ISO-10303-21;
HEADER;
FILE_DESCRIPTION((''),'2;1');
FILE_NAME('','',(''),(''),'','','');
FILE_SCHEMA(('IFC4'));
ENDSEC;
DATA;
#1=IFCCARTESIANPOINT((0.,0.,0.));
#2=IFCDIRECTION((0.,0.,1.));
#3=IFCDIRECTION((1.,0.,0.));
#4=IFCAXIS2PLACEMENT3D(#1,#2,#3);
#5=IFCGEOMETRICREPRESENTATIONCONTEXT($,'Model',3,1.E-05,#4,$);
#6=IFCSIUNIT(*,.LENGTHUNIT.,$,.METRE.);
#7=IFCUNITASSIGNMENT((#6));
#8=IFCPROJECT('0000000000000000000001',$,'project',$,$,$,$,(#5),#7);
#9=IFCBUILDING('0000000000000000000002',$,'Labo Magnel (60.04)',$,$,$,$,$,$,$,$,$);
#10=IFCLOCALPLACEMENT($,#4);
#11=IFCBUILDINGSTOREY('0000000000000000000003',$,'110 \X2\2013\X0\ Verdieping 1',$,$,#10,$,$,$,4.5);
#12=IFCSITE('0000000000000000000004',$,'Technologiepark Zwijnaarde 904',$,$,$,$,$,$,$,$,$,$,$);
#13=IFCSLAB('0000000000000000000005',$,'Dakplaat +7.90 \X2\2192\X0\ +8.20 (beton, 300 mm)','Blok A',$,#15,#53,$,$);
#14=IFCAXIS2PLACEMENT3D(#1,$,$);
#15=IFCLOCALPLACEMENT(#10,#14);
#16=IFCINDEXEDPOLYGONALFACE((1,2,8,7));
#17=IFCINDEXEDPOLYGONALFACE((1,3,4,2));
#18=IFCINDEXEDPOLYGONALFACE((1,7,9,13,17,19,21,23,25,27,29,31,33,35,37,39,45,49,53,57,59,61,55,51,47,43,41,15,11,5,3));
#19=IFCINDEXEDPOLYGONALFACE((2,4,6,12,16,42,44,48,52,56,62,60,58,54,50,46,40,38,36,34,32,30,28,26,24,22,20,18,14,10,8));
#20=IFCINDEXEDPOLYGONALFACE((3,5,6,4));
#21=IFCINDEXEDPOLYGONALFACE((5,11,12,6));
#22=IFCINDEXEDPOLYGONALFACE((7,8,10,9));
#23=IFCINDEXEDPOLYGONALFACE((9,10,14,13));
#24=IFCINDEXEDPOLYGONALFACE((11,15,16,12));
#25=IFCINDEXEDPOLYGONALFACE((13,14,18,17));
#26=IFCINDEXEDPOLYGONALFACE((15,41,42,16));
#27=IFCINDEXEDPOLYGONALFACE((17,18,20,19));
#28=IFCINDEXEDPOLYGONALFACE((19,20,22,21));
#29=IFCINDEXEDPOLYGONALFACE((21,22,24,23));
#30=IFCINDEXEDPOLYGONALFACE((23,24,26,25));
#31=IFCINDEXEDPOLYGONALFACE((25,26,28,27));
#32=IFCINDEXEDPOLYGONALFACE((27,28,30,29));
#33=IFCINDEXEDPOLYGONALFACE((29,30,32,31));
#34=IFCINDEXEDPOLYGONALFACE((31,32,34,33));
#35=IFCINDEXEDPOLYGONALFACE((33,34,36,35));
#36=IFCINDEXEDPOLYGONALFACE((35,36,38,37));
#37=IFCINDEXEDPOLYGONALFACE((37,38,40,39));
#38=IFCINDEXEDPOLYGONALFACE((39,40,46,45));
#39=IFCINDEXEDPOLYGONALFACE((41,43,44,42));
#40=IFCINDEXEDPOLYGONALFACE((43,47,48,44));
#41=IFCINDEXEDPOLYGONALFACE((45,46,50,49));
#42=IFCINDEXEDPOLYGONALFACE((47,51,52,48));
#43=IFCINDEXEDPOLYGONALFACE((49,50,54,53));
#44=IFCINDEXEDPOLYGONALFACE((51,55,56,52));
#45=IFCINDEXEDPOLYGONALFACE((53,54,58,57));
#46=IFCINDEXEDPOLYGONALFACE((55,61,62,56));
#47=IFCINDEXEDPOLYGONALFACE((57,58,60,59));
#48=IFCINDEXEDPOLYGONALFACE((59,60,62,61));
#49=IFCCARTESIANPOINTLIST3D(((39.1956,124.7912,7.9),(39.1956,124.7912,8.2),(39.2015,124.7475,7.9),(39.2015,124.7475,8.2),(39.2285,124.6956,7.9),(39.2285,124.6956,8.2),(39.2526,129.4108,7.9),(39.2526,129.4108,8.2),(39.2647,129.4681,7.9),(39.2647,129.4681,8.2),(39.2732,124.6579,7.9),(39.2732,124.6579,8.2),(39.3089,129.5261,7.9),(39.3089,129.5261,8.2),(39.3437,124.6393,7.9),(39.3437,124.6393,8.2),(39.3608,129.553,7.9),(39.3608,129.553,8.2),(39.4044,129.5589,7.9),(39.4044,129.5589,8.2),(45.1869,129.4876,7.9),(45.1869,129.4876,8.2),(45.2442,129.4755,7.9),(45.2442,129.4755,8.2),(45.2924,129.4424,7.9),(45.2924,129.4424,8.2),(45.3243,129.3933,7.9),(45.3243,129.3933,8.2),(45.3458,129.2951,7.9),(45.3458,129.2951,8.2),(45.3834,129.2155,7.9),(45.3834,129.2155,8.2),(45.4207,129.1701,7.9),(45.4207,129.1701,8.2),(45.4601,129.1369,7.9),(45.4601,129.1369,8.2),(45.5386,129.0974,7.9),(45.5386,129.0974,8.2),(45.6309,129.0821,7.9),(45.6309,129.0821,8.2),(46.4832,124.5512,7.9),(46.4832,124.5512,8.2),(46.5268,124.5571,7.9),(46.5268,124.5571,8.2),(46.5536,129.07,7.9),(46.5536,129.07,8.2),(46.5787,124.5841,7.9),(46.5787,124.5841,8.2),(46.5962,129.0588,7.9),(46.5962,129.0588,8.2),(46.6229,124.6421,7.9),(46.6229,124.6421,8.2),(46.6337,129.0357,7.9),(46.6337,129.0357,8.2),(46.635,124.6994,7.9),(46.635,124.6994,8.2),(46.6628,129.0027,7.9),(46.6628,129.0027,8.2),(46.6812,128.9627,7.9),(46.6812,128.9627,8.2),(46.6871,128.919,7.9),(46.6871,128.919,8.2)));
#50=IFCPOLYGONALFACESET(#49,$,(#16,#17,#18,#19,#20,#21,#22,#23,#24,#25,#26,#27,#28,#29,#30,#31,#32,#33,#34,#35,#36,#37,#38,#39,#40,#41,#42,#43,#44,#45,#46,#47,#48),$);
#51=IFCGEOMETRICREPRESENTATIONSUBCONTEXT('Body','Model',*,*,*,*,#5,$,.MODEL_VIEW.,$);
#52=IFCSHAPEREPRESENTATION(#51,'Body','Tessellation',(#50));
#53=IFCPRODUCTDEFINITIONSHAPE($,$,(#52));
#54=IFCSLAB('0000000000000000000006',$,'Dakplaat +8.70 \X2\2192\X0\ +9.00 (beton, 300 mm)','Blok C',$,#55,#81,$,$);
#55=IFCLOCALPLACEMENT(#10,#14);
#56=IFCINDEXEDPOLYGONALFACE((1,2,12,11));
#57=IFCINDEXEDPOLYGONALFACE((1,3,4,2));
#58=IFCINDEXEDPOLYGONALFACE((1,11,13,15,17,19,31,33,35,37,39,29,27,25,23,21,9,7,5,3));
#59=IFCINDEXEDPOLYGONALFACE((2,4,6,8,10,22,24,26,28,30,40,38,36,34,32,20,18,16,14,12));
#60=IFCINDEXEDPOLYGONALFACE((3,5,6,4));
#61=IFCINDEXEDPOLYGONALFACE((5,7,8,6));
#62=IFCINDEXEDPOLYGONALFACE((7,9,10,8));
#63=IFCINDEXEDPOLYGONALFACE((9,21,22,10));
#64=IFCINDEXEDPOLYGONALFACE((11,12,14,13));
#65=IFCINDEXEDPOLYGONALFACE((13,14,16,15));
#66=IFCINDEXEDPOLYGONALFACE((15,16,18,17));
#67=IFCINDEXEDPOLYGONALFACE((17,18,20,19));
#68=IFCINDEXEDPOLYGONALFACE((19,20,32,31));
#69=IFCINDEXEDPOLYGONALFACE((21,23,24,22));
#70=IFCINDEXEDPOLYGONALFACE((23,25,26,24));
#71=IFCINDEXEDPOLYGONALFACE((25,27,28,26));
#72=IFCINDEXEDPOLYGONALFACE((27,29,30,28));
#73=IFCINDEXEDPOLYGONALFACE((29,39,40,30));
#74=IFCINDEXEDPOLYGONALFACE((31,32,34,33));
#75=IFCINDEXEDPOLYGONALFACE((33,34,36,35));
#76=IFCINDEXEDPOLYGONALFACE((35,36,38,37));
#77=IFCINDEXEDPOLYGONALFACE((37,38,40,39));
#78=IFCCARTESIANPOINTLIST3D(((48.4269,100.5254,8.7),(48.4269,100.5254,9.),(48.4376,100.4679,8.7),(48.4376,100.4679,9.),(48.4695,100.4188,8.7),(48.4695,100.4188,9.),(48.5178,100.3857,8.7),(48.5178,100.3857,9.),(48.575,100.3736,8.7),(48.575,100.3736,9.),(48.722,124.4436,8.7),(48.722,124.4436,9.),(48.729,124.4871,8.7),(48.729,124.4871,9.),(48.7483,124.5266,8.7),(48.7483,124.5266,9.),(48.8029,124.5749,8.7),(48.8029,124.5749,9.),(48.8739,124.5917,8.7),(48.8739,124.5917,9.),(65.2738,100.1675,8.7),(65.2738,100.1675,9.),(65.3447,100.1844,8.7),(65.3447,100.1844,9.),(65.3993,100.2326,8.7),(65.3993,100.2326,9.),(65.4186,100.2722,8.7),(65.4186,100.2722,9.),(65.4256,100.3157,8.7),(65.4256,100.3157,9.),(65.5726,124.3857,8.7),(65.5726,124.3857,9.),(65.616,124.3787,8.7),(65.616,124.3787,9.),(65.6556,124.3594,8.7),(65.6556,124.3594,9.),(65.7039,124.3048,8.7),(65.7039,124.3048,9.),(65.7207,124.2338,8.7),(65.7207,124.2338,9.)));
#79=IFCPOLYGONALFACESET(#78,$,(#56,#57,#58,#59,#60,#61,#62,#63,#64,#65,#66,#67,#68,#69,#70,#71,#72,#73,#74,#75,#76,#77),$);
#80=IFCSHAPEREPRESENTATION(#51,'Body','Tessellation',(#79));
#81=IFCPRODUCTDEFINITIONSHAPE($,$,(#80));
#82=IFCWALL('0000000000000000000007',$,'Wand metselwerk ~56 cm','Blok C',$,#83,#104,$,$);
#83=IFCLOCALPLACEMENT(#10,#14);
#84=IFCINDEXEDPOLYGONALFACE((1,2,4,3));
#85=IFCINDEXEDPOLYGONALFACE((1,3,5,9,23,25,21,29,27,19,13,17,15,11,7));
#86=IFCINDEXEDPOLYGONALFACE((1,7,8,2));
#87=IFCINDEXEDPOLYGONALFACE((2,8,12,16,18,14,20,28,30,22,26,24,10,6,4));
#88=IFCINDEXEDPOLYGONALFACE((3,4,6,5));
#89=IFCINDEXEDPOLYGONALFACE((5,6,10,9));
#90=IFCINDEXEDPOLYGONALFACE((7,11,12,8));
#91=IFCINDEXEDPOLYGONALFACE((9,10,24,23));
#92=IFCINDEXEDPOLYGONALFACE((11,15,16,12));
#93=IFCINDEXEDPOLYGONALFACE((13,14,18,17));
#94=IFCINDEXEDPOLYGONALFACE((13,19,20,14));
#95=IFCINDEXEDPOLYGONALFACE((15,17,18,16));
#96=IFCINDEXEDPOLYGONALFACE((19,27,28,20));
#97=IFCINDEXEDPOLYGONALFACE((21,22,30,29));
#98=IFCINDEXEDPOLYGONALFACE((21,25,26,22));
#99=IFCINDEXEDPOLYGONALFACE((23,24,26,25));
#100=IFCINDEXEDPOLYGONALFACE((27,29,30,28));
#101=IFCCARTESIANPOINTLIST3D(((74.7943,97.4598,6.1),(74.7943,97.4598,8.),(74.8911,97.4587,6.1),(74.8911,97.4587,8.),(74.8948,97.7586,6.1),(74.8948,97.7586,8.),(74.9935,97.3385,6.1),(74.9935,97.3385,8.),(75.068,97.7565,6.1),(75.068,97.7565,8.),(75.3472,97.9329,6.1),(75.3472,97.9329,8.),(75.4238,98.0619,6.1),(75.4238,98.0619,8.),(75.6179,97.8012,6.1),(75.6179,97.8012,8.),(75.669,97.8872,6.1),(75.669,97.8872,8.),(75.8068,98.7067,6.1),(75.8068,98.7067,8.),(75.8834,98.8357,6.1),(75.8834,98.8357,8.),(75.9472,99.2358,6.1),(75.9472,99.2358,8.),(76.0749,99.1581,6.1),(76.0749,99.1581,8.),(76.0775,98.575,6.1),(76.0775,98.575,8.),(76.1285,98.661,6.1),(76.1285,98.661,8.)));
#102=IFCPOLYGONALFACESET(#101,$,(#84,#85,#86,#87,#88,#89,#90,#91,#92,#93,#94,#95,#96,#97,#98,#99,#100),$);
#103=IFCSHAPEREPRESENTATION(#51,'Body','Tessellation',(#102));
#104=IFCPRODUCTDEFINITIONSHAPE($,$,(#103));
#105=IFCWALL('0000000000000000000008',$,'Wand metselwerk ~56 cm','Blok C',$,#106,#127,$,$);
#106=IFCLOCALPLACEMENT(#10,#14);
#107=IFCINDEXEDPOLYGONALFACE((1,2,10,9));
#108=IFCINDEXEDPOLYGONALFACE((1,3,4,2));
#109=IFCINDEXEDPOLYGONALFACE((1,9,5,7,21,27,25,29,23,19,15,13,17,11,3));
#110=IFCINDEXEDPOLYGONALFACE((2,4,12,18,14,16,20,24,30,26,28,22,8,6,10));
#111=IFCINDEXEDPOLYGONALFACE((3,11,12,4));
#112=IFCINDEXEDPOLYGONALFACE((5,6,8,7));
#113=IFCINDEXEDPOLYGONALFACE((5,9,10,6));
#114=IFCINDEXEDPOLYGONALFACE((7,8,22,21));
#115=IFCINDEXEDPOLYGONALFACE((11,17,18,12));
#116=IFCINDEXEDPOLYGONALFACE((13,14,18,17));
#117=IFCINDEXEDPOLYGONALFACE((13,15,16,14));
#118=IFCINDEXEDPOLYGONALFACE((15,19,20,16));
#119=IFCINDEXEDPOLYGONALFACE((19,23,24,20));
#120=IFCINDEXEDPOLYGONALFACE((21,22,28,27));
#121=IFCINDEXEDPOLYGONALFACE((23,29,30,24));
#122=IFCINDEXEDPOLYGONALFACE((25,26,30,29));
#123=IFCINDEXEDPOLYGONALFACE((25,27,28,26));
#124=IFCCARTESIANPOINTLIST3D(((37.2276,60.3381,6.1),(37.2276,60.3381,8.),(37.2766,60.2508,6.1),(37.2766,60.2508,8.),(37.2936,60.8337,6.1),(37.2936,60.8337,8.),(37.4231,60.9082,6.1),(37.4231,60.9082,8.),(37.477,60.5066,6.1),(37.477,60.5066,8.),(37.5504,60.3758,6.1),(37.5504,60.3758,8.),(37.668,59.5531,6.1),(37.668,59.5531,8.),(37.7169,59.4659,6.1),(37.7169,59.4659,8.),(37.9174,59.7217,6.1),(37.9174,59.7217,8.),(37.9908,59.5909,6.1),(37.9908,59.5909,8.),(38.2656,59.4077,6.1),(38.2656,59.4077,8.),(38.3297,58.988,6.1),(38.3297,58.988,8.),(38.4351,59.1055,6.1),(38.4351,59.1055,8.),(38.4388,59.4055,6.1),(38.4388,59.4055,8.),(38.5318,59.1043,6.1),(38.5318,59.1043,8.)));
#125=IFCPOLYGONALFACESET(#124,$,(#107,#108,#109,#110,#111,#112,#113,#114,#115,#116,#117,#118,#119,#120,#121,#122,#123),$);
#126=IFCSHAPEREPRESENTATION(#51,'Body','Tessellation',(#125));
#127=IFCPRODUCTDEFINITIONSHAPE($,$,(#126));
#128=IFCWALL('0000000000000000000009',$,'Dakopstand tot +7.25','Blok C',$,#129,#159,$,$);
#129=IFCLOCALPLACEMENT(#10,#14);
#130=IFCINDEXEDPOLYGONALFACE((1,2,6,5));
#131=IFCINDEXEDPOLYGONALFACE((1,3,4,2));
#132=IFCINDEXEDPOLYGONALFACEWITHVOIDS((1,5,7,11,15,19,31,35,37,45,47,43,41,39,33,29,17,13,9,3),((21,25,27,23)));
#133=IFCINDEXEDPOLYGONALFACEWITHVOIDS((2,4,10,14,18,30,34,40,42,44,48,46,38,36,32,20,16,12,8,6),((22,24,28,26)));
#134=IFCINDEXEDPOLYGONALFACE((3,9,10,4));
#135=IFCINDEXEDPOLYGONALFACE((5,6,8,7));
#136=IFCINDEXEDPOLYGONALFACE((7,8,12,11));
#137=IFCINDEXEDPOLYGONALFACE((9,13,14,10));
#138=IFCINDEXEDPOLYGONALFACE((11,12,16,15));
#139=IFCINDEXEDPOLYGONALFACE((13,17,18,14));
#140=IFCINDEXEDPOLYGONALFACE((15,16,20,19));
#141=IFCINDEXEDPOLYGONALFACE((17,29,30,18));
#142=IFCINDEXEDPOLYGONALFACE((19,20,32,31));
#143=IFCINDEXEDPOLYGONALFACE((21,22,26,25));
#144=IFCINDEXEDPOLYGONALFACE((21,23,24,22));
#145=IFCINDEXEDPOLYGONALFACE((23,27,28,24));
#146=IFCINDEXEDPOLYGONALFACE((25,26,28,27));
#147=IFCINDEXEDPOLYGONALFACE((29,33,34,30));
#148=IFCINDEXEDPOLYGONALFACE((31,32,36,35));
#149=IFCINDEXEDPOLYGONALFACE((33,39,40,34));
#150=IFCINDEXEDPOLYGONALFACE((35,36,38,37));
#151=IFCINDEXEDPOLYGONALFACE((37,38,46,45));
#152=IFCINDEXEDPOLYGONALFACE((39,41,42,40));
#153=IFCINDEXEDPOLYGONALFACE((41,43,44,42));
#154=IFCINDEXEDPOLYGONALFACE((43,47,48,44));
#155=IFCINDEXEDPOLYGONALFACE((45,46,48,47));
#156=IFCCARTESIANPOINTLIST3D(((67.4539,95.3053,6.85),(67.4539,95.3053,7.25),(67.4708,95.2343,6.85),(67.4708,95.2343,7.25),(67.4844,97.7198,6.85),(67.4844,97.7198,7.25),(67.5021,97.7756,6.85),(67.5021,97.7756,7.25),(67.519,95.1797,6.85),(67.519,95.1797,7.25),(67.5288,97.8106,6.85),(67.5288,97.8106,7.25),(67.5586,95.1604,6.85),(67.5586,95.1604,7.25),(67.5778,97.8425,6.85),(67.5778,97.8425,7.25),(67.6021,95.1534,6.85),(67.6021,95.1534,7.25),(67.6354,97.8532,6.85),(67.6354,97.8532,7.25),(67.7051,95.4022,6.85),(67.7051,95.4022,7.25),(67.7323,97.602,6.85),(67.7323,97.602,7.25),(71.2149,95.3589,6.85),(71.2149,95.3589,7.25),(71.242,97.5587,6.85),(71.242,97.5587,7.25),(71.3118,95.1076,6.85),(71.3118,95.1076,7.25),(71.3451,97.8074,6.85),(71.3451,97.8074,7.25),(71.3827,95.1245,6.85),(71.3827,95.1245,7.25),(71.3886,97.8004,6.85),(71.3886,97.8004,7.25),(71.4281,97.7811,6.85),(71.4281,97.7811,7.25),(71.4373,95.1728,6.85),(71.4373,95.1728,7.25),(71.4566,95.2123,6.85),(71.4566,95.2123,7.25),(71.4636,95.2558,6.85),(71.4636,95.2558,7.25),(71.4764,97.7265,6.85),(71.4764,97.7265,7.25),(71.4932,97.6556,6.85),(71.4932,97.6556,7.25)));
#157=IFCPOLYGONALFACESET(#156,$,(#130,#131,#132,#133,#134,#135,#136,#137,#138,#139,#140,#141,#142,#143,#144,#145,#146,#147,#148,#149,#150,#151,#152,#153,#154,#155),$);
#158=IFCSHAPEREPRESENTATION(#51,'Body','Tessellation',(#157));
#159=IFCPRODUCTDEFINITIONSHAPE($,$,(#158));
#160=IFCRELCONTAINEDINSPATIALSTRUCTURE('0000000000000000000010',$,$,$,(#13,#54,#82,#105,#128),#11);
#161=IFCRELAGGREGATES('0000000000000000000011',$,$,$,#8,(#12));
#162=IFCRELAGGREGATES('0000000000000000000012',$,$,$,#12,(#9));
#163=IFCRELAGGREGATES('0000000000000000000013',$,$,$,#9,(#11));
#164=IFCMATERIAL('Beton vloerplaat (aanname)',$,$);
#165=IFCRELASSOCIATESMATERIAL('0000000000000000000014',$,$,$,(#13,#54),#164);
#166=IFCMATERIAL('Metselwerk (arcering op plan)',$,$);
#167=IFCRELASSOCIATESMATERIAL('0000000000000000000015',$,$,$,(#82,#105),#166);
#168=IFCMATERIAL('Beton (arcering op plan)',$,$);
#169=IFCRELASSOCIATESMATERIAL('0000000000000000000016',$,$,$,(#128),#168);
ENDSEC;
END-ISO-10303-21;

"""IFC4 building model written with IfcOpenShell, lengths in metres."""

from ifc_helpers import new_model, si_unit, frame, origin, origin_with_axes, place, context, subcontext, project, spatial, polyline, outline, extrude, material, element, save


model = new_model("IFC4")

# Units and contexts
model_context = context("Model", 3, precision=1e-05, world=origin_with_axes())
body_context = subcontext(model_context, "Body", "Model", "MODEL_VIEW")
ifc_project = project(units=[si_unit("LENGTHUNIT", "METRE")], contexts=[model_context])

# Site, building, storey
site = spatial("IfcSite", under=ifc_project, Name="Technologiepark Zwijnaarde 904")
building = spatial("IfcBuilding", under=site, Name="Labo Magnel (60.04)")
storey_placement = place(None, origin_with_axes())
storey = spatial("IfcBuildingStorey", under=building, at=storey_placement, Name="110 – Verdieping 1", Elevation=4.5)

# Shared definitions
ifc_material_1 = material(Name="Metselwerk (arcering op plan)")
ifc_material_2 = material(Name="Beton (arcering op plan)")

# Slabs
ifc_material_3 = material(Name="Beton vloerplaat (aanname)")
slab_1_placement = place(storey_placement, frame((0.0, 0.0, 7.9), z_axis=(0.0, 0.0, 1.0), x_axis=(1.0, 0.0, 0.0)))
element("IfcSlab", 1, at=slab_1_placement, inside=storey, material=ifc_material_3, Name="Dakplaat +7.90 → +8.20 (beton, 300 mm)", Description="Blok A", context=body_context, shape_type="SweptSolid", body=[
    extrude(outline(polyline([(45.1869, 129.4876), (45.2442, 129.4755), (45.2924, 129.4424), (45.3243, 129.3933), (45.3458, 129.2951), (45.3834, 129.2155), (45.4207, 129.1701), (45.4601, 129.1369), (45.5386, 129.0974), (45.6309, 129.0821), (46.5536, 129.07), (46.5962, 129.0588), (46.6337, 129.0357), (46.6628, 129.0027), (46.6812, 128.9627), (46.6871, 128.919), (46.635, 124.6994), (46.6229, 124.6421), (46.5787, 124.5841), (46.5268, 124.5571), (46.4832, 124.5512), (39.3437, 124.6393), (39.2732, 124.6579), (39.2285, 124.6956), (39.2015, 124.7475), (39.1956, 124.7912), (39.2526, 129.4108), (39.2647, 129.4681), (39.3089, 129.5261), (39.3608, 129.553), (39.4044, 129.5589), (45.1869, 129.4876)])), origin(), (0.0, 0.0, 1.0), 0.3),
])
slab_2_placement = place(storey_placement, frame((0.0, 0.0, 8.7), z_axis=(0.0, 0.0, 1.0), x_axis=(1.0, 0.0, 0.0)))
element("IfcSlab", 2, at=slab_2_placement, inside=storey, material=ifc_material_3, Name="Dakplaat +8.70 → +9.00 (beton, 300 mm)", Description="Blok C", context=body_context, shape_type="SweptSolid", body=[
    extrude(outline(polyline([(48.575, 100.3736), (48.5178, 100.3857), (48.4695, 100.4188), (48.4376, 100.4679), (48.4269, 100.5254), (48.722, 124.4436), (48.729, 124.4871), (48.7483, 124.5266), (48.8029, 124.5749), (48.8739, 124.5917), (65.5726, 124.3857), (65.616, 124.3787), (65.6556, 124.3594), (65.7039, 124.3048), (65.7207, 124.2338), (65.4256, 100.3157), (65.4186, 100.2722), (65.3993, 100.2326), (65.3447, 100.1844), (65.2738, 100.1675), (48.575, 100.3736)])), origin(), (0.0, 0.0, 1.0), 0.3),
])

# Walls
wall_1_placement = place(storey_placement, frame((0.0, 0.0, 6.1), z_axis=(0.0, 0.0, 1.0), x_axis=(1.0, 0.0, 0.0)))
element("IfcWall", 3, at=wall_1_placement, inside=storey, material=ifc_material_1, Name="Wand metselwerk ~56 cm", Description="Blok C", context=body_context, shape_type="SweptSolid", body=[
    extrude(outline(polyline([(75.3472, 97.9329), (75.6179, 97.8012), (75.669, 97.8872), (75.4238, 98.0619), (75.8068, 98.7067), (76.0775, 98.575), (76.1285, 98.661), (75.8834, 98.8357), (76.0749, 99.1581), (75.9472, 99.2358), (75.068, 97.7565), (74.8948, 97.7586), (74.8911, 97.4587), (74.7943, 97.4598), (74.9935, 97.3385), (75.3472, 97.9329)])), origin(), (0.0, 0.0, 1.0), 1.9),
])
wall_2_placement = place(storey_placement, frame((0.0, 0.0, 6.1), z_axis=(0.0, 0.0, 1.0), x_axis=(1.0, 0.0, 0.0)))
element("IfcWall", 4, at=wall_2_placement, inside=storey, material=ifc_material_1, Name="Wand metselwerk ~56 cm", Description="Blok C", context=body_context, shape_type="SweptSolid", body=[
    extrude(outline(polyline([(38.4388, 59.4055), (38.2656, 59.4077), (37.4231, 60.9082), (37.2936, 60.8337), (37.477, 60.5066), (37.2276, 60.3381), (37.2766, 60.2508), (37.5504, 60.3758), (37.9174, 59.7217), (37.668, 59.5531), (37.7169, 59.4659), (37.9908, 59.5909), (38.3297, 58.988), (38.5318, 59.1043), (38.4351, 59.1055), (38.4388, 59.4055)])), origin(), (0.0, 0.0, 1.0), 1.9),
])
wall_3_placement = place(storey_placement, frame((0.0, 0.0, 6.85), z_axis=(0.0, 0.0, 1.0), x_axis=(1.0, 0.0, 0.0)))
element("IfcWall", 5, at=wall_3_placement, inside=storey, material=ifc_material_2, Name="Dakopstand tot +7.25", Description="Blok C", context=body_context, shape_type="SweptSolid", body=[
    extrude(outline(polyline([(67.4844, 97.7198), (67.5021, 97.7756), (67.5288, 97.8106), (67.5778, 97.8425), (67.6354, 97.8532), (71.3451, 97.8074), (71.3886, 97.8004), (71.4281, 97.7811), (71.4764, 97.7265), (71.4932, 97.6556), (71.4636, 95.2558), (71.4566, 95.2123), (71.4373, 95.1728), (71.3827, 95.1245), (71.3118, 95.1076), (67.6021, 95.1534), (67.5586, 95.1604), (67.519, 95.1797), (67.4708, 95.2343), (67.4539, 95.3053), (67.4844, 97.7198)]), holes=[polyline([(71.2149, 95.3589), (71.242, 97.5587), (67.7323, 97.602), (67.7051, 95.4022), (71.2149, 95.3589)])]), origin(), (0.0, 0.0, 1.0), 0.4),
])

save(model, "model.ifc")
